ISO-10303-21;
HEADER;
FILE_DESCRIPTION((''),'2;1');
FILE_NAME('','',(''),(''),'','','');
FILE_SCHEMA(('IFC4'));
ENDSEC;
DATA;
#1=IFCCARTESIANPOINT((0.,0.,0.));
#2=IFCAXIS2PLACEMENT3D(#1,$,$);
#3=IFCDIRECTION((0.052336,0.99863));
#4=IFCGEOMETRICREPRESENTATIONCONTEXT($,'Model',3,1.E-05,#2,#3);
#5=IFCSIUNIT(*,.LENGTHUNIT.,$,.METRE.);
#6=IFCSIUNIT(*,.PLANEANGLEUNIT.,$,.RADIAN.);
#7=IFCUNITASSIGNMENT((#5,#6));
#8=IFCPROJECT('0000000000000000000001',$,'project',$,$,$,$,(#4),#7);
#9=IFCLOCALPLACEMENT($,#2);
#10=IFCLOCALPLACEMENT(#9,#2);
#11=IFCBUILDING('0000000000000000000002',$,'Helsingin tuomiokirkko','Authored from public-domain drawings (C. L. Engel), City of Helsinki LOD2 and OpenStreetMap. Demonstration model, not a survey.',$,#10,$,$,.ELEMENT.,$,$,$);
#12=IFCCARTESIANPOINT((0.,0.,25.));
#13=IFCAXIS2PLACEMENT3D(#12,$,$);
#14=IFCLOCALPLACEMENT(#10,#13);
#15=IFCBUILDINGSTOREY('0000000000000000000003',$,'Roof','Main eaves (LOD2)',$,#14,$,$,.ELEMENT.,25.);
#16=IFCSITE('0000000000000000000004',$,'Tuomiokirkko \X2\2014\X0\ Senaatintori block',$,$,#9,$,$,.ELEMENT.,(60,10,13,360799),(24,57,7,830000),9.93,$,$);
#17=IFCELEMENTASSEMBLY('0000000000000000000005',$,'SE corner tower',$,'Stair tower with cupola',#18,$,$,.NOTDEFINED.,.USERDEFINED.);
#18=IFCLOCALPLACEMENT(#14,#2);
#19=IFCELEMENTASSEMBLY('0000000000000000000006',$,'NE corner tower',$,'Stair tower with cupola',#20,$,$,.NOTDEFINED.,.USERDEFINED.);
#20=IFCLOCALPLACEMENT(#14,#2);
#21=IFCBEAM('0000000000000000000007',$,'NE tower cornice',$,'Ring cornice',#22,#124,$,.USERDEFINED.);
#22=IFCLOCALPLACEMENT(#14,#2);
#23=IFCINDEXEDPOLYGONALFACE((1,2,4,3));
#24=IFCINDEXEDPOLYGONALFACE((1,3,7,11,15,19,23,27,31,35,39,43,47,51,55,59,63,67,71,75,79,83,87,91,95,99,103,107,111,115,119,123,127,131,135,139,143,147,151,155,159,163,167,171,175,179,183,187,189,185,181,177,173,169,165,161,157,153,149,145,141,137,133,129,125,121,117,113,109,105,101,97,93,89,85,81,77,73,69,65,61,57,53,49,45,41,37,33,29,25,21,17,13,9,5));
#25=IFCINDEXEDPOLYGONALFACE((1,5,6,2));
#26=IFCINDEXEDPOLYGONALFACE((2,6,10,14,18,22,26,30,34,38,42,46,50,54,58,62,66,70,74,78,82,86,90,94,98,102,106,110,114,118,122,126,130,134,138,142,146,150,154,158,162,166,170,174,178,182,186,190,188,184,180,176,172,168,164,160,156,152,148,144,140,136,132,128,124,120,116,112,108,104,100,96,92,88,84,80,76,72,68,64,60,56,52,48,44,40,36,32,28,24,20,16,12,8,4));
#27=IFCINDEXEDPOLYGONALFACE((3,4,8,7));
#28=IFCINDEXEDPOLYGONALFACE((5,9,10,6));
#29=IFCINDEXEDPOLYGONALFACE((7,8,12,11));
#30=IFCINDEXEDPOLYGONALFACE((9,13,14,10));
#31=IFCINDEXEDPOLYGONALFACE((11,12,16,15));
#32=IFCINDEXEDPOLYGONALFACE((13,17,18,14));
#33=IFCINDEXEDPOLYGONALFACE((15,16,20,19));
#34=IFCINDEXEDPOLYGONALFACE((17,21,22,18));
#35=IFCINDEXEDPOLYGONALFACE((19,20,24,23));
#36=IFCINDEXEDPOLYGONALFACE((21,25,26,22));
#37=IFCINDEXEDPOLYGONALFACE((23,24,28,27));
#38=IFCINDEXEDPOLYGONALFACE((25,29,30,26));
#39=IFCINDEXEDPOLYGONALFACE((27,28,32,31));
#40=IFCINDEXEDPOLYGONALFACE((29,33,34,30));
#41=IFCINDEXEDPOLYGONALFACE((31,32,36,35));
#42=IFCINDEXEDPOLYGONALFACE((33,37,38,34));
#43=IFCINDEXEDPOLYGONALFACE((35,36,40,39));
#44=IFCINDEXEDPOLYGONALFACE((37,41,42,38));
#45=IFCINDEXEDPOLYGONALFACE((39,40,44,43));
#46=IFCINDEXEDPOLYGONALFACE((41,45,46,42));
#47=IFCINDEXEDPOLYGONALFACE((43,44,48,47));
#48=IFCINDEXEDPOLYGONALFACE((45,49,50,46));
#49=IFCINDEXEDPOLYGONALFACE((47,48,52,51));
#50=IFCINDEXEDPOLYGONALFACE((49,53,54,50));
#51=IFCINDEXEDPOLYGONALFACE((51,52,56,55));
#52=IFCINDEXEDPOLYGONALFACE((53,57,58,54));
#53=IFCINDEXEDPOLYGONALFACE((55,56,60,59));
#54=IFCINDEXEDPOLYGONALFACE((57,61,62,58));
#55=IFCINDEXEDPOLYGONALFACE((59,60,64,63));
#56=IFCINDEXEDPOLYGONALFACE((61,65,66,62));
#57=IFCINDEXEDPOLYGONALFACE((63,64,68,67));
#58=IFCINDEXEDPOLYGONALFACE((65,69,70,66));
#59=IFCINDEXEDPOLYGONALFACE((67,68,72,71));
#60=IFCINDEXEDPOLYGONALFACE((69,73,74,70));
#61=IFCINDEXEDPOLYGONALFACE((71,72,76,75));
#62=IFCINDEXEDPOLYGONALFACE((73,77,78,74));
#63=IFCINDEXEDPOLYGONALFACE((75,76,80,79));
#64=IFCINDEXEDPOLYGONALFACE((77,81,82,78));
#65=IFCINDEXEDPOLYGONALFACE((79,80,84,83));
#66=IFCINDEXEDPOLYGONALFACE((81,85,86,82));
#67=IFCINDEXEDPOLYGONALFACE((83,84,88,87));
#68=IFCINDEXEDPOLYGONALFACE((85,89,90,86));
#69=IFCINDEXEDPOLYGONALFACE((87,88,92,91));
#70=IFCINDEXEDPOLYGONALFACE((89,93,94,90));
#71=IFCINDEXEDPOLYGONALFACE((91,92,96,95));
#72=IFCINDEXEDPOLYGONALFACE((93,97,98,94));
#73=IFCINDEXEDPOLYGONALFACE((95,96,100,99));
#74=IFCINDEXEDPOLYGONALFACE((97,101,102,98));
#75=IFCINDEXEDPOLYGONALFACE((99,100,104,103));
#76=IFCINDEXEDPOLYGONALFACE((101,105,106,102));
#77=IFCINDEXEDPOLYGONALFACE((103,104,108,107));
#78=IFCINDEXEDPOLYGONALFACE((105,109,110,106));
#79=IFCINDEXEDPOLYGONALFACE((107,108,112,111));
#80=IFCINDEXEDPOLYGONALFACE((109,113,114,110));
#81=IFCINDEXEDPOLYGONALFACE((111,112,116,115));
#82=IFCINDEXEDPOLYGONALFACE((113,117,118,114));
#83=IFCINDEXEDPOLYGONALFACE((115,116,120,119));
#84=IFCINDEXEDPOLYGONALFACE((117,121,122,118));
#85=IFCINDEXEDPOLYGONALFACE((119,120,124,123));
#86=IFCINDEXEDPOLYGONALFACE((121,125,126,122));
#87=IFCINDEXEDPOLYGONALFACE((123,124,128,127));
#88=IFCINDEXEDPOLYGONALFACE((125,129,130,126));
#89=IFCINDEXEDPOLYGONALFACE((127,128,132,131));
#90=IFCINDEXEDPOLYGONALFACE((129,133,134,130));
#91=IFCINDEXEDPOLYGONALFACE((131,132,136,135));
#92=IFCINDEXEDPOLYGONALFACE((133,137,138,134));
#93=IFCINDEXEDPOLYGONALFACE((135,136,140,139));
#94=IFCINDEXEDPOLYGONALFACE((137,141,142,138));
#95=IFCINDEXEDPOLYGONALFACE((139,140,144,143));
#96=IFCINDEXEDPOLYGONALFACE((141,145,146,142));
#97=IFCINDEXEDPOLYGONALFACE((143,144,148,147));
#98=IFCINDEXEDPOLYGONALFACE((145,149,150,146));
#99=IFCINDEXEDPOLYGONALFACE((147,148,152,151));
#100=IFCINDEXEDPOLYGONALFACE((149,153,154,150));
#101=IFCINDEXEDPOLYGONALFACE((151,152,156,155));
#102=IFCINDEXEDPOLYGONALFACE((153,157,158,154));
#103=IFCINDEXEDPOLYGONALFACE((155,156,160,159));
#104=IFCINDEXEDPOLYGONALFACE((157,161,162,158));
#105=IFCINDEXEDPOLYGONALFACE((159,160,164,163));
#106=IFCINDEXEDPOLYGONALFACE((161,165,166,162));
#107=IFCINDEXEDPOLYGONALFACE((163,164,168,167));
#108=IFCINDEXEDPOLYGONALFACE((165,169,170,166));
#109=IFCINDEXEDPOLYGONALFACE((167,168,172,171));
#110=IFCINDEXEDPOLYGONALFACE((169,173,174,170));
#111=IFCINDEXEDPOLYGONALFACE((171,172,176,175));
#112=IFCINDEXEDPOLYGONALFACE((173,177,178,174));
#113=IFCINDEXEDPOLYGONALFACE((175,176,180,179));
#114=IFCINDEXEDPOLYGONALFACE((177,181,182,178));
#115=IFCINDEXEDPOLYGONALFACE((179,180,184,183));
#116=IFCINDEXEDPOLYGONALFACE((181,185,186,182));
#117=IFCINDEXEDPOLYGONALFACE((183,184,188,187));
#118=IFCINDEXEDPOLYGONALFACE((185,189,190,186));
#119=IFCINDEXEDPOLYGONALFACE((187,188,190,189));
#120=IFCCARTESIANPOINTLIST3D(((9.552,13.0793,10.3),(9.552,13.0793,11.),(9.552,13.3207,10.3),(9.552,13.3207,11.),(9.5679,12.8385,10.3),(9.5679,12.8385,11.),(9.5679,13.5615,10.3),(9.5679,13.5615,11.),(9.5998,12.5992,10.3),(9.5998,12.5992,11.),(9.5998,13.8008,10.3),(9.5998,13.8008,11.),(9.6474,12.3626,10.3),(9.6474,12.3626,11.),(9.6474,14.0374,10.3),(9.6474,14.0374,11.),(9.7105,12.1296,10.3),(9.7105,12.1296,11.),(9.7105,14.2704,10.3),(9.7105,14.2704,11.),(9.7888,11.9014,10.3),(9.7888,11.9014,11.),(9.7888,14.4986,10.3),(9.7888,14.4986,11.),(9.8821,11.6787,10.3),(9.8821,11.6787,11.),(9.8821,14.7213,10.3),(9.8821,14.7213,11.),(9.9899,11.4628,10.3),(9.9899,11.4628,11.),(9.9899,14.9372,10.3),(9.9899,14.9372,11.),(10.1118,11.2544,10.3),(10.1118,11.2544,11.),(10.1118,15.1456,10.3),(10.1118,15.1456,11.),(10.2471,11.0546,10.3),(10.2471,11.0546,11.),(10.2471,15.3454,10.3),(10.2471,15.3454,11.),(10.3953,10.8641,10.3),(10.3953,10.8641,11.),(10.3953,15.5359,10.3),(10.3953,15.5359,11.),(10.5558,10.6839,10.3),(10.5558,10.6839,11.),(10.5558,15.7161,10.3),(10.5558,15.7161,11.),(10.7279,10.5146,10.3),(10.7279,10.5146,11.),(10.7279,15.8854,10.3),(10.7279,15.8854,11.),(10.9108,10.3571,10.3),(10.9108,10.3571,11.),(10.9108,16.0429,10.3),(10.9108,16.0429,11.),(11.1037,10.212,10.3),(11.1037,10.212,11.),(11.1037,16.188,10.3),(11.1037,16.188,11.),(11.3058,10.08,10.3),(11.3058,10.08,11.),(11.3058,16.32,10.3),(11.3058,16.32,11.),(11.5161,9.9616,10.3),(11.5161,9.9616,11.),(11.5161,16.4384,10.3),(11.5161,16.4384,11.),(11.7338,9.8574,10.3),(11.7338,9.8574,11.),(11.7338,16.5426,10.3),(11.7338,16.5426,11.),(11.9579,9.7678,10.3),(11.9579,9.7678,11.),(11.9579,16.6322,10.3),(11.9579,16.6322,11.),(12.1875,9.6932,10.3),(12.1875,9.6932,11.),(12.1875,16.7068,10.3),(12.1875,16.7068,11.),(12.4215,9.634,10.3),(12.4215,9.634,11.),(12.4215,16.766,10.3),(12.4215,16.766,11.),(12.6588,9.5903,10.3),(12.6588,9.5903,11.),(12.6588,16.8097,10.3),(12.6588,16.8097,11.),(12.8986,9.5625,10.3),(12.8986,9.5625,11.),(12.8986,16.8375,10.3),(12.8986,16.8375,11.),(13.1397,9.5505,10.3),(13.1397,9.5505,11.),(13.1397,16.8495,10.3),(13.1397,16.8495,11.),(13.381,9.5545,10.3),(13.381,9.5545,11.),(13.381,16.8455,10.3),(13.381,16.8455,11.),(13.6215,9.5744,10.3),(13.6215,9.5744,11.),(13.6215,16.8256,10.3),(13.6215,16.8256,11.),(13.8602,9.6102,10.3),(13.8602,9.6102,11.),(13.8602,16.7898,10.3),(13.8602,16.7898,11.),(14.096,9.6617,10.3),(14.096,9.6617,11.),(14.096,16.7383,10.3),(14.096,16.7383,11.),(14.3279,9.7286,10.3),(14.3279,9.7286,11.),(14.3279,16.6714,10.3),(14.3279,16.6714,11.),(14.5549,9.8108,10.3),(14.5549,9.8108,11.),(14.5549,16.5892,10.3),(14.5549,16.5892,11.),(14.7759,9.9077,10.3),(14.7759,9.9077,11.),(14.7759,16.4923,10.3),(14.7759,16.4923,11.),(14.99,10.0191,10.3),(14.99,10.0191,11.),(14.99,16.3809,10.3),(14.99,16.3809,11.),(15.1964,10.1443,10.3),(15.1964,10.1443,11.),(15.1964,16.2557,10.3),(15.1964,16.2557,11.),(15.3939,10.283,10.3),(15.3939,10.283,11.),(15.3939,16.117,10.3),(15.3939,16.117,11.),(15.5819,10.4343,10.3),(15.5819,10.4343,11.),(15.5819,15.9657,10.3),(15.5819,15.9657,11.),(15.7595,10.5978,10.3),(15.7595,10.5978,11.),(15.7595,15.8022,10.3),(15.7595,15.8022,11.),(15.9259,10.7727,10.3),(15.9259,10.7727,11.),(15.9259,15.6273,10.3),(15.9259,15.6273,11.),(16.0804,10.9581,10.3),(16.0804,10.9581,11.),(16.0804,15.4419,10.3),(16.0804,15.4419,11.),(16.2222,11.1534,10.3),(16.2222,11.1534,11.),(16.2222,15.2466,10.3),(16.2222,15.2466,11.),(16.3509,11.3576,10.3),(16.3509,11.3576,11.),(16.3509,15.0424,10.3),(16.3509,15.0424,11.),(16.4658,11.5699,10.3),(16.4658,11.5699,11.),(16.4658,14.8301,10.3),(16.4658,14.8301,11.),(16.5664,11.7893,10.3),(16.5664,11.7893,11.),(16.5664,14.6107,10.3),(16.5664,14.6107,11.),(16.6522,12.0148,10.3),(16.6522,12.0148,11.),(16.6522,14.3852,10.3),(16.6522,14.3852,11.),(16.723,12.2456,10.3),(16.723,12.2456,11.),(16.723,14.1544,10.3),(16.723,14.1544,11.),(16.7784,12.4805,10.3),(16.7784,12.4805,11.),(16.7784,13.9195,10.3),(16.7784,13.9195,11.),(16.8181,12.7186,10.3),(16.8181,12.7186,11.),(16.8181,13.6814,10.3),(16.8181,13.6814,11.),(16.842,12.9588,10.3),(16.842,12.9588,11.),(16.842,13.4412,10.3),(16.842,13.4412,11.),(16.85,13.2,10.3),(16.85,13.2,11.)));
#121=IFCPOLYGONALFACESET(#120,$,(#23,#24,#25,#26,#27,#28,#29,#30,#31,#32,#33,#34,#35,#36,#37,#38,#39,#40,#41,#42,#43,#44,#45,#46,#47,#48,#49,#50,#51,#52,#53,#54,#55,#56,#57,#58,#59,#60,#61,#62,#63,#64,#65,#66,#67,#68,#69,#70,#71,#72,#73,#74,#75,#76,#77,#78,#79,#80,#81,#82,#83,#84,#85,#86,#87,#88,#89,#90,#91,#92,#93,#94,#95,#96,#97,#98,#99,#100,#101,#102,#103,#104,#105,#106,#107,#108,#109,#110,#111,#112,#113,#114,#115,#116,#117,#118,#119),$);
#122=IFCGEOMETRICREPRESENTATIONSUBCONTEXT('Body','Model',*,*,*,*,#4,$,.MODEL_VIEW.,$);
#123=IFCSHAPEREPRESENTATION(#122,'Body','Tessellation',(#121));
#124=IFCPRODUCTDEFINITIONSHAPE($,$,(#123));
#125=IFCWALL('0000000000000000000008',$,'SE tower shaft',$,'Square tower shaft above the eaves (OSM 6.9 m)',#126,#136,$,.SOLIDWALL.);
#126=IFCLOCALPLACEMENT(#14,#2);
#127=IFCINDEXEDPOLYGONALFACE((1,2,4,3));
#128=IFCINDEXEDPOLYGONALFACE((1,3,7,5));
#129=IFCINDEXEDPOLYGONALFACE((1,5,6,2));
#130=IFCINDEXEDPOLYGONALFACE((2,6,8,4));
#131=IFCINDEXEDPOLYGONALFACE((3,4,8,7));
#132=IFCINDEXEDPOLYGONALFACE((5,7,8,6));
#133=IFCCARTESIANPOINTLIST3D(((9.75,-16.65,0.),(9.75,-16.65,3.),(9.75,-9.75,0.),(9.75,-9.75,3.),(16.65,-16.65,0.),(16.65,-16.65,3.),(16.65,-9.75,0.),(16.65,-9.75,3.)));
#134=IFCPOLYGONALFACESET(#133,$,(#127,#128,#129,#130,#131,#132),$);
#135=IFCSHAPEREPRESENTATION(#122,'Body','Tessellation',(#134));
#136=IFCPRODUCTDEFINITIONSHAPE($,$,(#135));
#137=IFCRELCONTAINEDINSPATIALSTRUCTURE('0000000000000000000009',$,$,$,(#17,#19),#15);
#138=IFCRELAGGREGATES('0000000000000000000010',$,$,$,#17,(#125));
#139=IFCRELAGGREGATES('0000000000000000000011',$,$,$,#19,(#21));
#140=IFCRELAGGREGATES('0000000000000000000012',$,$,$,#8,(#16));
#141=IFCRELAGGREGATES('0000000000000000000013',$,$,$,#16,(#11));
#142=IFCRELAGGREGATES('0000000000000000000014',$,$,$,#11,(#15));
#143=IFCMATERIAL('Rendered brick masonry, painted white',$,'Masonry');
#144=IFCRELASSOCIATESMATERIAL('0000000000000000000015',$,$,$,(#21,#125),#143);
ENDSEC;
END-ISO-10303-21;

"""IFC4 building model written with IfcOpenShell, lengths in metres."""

from ifc_helpers import new_model, si_unit, direction, frame, origin, origin_2d_with_axis, place, context, subcontext, project, spatial, rectangle, circle, extrude, material, element, aggregate, save


model = new_model("IFC4")

# Units and contexts
model_context = context("Model", 3, precision=1e-05, world=origin(), true_north=direction((0.052336, 0.99863)))
body_context = subcontext(model_context, "Body", "Model", "MODEL_VIEW")
ifc_project = project(units=[si_unit("LENGTHUNIT", "METRE"), si_unit("PLANEANGLEUNIT", "RADIAN")], contexts=[model_context])

# Site, building, storey
site_placement = place(None, origin())
site = spatial("IfcSite", under=ifc_project, at=site_placement, Name="Tuomiokirkko — Senaatintori block", CompositionType="ELEMENT", RefLatitude=(60, 10, 13, 360799), RefLongitude=(24, 57, 7, 830000), RefElevation=9.93)
building_placement = place(site_placement, origin())
building = spatial("IfcBuilding", under=site, at=building_placement, Name="Helsingin tuomiokirkko", Description="Authored from public-domain drawings (C. L. Engel), City of Helsinki LOD2 and OpenStreetMap. Demonstration model, not a survey.", CompositionType="ELEMENT")
storey_placement = place(building_placement, frame((0.0, 0.0, 25.0)))
storey = spatial("IfcBuildingStorey", under=building, at=storey_placement, Name="Roof", Description="Main eaves (LOD2)", CompositionType="ELEMENT", Elevation=25.0)

# Element assemblies
assembly_1_placement = place(building_placement, origin())
assembly_1 = element("IfcElementAssembly", 1, at=assembly_1_placement, inside=storey, Name="SE corner tower", ObjectType="Stair tower with cupola", AssemblyPlace="NOTDEFINED", PredefinedType="USERDEFINED")
assembly_2_placement = place(building_placement, origin())
assembly_2 = element("IfcElementAssembly", 2, at=assembly_2_placement, inside=storey, Name="NE corner tower", ObjectType="Stair tower with cupola", AssemblyPlace="NOTDEFINED", PredefinedType="USERDEFINED")

# Shared definitions
ifc_material_1 = material(Name="Rendered brick masonry, painted white", Category="Masonry")

# Beam
beam_1_placement = place(building_placement, origin())
beam_1 = element("IfcBeam", 3, at=beam_1_placement, material=ifc_material_1, Name="NE tower cornice", ObjectType="Ring cornice", PredefinedType="USERDEFINED", context=body_context, shape_type="SweptSolid", body=[
    extrude(circle(Radius=3.65, at=origin_2d_with_axis()), frame((13.2, 13.2, 35.3)), (0.0, 0.0, 1.0), 0.7),
])

# Wall
wall_1_placement = place(building_placement, origin())
wall_1 = element("IfcWall", 4, at=wall_1_placement, material=ifc_material_1, Name="SE tower shaft", ObjectType="Square tower shaft above the eaves (OSM 6.9 m)", PredefinedType="SOLIDWALL", context=body_context, shape_type="SweptSolid", body=[
    extrude(rectangle(XDim=6.9, YDim=6.9, at=origin_2d_with_axis()), frame((13.2, -13.2, 25.0)), (0.0, 0.0, 1.0), 3.0),
])

aggregate(assembly_1, [wall_1])
aggregate(assembly_2, [beam_1])

save(model, "model.ifc")
